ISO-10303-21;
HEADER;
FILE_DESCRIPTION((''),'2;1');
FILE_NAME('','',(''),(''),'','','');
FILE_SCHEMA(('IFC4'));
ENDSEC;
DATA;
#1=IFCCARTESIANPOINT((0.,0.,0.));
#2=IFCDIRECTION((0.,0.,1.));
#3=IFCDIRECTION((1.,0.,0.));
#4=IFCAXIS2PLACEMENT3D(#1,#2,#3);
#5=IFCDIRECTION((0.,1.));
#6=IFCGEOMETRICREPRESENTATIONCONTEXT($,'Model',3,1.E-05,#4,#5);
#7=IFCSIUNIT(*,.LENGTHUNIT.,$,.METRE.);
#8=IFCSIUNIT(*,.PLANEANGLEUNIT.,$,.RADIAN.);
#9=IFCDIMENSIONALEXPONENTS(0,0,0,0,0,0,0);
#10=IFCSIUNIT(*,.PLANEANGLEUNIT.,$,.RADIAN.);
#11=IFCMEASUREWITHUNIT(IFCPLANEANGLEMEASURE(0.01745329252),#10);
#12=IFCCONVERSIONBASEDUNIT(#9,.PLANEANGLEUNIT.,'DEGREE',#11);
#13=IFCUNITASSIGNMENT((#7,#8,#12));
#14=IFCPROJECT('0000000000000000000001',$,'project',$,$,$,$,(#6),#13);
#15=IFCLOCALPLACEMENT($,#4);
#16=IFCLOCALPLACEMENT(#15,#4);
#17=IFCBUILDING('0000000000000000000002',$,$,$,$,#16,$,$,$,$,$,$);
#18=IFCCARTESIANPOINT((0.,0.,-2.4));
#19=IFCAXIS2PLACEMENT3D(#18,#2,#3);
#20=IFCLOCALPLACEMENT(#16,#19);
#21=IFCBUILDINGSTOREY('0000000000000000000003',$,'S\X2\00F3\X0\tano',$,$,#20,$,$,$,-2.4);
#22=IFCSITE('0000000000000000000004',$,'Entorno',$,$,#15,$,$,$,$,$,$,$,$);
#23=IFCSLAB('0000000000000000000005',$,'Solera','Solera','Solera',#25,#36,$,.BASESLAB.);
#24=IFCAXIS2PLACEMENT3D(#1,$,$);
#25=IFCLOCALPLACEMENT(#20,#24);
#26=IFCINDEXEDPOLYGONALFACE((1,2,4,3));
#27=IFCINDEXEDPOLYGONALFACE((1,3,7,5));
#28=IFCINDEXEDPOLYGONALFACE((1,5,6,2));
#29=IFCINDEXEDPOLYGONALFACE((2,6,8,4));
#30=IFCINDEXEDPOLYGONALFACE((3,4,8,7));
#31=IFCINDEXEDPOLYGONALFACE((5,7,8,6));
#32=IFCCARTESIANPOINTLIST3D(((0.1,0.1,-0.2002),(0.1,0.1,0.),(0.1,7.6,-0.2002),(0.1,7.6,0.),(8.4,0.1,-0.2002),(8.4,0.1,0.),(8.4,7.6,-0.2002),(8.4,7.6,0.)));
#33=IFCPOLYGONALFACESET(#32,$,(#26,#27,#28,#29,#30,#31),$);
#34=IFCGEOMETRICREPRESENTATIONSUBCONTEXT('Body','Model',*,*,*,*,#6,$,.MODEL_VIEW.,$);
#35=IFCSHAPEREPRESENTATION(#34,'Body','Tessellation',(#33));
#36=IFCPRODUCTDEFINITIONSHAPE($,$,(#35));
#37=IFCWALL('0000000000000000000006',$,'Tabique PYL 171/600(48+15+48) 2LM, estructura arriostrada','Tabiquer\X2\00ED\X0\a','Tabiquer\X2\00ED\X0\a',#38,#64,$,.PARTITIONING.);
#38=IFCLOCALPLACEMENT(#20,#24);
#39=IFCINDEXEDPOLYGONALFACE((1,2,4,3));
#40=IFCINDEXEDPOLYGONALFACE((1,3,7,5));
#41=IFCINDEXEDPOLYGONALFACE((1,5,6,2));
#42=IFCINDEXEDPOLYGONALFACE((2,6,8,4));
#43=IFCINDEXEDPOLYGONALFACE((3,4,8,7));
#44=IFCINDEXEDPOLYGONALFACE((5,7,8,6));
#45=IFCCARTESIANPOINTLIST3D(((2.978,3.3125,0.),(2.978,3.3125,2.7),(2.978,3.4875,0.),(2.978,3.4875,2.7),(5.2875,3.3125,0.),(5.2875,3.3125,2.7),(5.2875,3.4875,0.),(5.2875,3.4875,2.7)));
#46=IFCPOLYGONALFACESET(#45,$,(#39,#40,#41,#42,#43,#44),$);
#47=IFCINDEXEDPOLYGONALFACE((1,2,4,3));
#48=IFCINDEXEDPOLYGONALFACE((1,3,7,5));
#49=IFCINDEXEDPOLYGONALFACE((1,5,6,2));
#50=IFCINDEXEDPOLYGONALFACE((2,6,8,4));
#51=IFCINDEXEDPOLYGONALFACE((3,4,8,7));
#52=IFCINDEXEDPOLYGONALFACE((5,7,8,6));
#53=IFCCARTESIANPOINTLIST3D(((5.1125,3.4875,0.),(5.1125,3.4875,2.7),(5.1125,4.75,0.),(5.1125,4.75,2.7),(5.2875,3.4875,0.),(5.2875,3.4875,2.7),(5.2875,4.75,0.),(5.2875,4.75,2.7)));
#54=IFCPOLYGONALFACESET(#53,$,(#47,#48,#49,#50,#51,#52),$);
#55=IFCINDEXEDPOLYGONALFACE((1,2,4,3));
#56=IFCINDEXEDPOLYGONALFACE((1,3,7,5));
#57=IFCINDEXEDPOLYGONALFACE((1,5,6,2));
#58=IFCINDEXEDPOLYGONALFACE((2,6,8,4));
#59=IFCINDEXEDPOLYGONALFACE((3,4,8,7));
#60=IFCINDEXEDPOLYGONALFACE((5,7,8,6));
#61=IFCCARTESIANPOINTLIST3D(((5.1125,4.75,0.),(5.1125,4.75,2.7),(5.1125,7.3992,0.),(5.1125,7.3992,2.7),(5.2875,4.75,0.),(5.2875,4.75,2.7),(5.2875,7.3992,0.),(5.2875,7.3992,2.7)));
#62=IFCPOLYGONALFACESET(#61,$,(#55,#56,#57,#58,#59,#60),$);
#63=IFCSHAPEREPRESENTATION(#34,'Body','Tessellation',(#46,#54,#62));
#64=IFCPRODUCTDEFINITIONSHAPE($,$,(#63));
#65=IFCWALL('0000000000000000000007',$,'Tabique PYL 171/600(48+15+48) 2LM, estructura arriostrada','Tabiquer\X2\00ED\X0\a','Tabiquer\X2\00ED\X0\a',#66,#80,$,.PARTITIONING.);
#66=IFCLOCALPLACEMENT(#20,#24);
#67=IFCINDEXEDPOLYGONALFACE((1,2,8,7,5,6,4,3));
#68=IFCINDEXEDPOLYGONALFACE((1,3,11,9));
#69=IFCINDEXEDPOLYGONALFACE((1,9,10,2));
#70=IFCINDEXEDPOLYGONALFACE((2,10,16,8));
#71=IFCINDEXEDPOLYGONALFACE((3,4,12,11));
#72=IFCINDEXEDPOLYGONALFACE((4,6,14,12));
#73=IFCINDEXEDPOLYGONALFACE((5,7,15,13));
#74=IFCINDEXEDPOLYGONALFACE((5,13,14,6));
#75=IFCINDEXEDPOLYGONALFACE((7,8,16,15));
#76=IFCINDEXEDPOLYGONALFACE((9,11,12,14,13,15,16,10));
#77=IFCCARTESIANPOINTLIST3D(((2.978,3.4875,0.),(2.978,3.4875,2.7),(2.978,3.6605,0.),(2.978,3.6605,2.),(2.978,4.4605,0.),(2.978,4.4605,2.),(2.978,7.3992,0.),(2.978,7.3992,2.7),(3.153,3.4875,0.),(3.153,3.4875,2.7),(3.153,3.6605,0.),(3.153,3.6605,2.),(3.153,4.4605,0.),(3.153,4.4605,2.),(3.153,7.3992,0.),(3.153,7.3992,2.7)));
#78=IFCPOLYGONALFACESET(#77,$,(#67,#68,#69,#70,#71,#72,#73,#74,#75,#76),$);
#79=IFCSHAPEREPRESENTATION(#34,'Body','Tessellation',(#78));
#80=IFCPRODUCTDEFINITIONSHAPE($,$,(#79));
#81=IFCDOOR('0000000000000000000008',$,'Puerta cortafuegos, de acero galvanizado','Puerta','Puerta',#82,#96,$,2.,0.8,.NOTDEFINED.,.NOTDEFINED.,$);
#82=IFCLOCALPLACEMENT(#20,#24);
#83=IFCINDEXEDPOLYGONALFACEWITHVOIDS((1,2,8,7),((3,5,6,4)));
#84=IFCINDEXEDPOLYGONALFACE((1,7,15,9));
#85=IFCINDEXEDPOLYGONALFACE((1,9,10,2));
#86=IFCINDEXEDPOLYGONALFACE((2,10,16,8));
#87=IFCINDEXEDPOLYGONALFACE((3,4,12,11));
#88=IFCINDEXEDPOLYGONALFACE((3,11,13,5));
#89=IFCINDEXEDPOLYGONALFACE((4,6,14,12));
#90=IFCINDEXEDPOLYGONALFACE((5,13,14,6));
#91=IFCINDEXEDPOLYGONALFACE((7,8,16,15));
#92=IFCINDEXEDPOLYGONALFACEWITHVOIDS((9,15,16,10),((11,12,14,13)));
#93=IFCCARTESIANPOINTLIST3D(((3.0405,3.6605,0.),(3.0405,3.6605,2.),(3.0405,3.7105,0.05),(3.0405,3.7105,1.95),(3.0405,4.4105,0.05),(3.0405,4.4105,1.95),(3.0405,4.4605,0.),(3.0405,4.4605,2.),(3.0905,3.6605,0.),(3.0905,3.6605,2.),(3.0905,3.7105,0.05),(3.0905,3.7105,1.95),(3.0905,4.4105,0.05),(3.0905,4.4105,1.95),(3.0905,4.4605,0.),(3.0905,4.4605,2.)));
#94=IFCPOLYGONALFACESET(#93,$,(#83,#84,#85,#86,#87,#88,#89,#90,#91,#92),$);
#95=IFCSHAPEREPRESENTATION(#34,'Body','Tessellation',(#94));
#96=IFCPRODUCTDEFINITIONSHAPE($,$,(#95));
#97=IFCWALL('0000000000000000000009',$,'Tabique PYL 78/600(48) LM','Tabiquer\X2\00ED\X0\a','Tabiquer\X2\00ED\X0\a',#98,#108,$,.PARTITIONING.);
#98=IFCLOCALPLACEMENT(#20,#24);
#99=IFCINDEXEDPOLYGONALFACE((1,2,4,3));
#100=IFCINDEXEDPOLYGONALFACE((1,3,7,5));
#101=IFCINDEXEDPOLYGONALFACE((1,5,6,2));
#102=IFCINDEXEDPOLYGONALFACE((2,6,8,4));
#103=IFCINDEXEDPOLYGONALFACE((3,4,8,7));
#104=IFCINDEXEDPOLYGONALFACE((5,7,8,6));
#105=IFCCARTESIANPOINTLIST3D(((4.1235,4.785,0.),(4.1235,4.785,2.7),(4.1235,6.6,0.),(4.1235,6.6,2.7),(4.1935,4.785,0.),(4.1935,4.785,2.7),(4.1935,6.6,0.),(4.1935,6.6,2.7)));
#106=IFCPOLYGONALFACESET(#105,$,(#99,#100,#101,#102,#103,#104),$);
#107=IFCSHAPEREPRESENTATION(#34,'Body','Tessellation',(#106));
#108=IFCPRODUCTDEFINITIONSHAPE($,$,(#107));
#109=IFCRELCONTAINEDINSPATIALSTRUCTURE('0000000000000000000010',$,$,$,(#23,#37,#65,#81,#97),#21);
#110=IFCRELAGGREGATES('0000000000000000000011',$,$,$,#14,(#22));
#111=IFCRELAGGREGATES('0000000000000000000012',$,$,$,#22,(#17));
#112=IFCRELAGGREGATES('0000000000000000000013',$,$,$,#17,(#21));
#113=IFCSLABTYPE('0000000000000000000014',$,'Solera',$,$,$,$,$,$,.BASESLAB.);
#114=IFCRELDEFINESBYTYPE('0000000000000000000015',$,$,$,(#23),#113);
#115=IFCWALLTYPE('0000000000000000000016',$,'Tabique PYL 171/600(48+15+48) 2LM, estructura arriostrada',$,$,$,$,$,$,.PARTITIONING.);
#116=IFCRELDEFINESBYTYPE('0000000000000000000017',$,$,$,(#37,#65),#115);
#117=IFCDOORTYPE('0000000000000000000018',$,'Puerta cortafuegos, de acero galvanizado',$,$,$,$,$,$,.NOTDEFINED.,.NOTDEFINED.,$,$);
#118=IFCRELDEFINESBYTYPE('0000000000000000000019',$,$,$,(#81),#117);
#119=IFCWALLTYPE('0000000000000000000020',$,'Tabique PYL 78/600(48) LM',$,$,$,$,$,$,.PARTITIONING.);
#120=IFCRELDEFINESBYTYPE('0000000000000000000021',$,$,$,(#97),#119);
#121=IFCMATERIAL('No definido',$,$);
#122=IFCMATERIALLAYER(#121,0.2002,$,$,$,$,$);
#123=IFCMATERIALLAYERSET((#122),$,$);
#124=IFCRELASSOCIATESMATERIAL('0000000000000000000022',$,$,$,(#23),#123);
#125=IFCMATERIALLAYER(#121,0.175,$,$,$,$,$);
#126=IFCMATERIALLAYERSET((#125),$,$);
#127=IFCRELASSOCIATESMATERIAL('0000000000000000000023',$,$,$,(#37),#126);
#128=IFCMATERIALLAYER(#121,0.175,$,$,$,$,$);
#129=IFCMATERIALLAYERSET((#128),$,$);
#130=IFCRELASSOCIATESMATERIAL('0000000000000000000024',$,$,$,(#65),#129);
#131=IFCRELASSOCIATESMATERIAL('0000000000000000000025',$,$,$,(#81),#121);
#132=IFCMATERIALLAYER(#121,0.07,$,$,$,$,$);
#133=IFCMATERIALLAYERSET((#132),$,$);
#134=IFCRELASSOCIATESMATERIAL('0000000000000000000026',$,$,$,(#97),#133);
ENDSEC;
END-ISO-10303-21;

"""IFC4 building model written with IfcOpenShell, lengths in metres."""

from ifc_helpers import new_model, entity, si_unit, converted_unit, direction, frame, origin_with_axes, origin_2d_with_axis, place, context, subcontext, project, spatial, polyline, rectangle, hollow_rectangle, outline, extrude, shape, material, layer, layer_set, layer_usage, type_object, element, fill, save


model = new_model("IFC4")

# Units and contexts
model_context = context("Model", 3, precision=1e-05, world=origin_with_axes(), true_north=direction((0.0, 1.0)))
body_context = subcontext(model_context, "Body", "Model", "MODEL_VIEW")
footprint_context = subcontext(model_context, "FootPrint", "Model", "MODEL_VIEW")
ifc_project = project(units=[si_unit("LENGTHUNIT", "METRE"), si_unit("PLANEANGLEUNIT", "RADIAN"), converted_unit("PLANEANGLEUNIT", "DEGREE", entity("IfcPlaneAngleMeasure", 0.01745329252), si_unit("PLANEANGLEUNIT", "RADIAN"), dimensions=[0, 0, 0, 0, 0, 0, 0])], contexts=[model_context])

# Site, building, storey
site_placement = place(None, origin_with_axes())
site = spatial("IfcSite", under=ifc_project, at=site_placement, Name="Entorno")
building_placement = place(site_placement, origin_with_axes())
building = spatial("IfcBuilding", under=site, at=building_placement)
storey_placement = place(building_placement, frame((0.0, 0.0, -2.4), z_axis=(0.0, 0.0, 1.0), x_axis=(1.0, 0.0, 0.0)))
storey = spatial("IfcBuildingStorey", under=building, at=storey_placement, Name="Sótano", Elevation=-2.4)

# Slab
ifc_material = material(Name="No definido")
ifc_layer_1 = layer(ifc_material, 0.2002)
ifc_layer_set_1 = layer_set([ifc_layer_1])
ifc_layer_usage_1 = layer_usage(ifc_layer_set_1, "AXIS3", "POSITIVE", 0.0)
slab_type = type_object("IfcSlabType", Name="Solera", PredefinedType="BASESLAB")
slab_placement = place(storey_placement, frame((0.1, 0.1, -0.2002), z_axis=(0.0, 0.0, 1.0), x_axis=(1.0, 0.0, 0.0)))
element("IfcSlab", 1, at=slab_placement, inside=storey, type_object=slab_type, material=ifc_layer_usage_1, Name="Solera", Description="Solera", ObjectType="Solera", PredefinedType="BASESLAB", context=body_context, shape_type="SweptSolid", body=[
    extrude(outline(polyline([(0.0, 0.0), (8.3, 0.0), (8.3, 7.5), (0.0, 7.5), (0.0, 0.0)])), origin_with_axes(), (0.0, 0.0, 1.0), 0.2002),
])

# Wall
ifc_layer_2 = layer(ifc_material, 0.175)
ifc_layer_set_2 = layer_set([ifc_layer_2])
ifc_layer_usage_2 = layer_usage(ifc_layer_set_2, "AXIS2", "POSITIVE", -0.0875)
wall_type_1 = type_object("IfcWallType", Name="Tabique PYL 171/600(48+15+48) 2LM, estructura arriostrada", PredefinedType="PARTITIONING")
wall_1_placement = place(storey_placement, frame((3.0655, 3.4, 0.0), z_axis=(0.0, 0.0, 1.0), x_axis=(1.0, 0.0, 0.0)))
cartesian_point_1 = entity("IfcCartesianPoint", [-1.1547, -1.35])
cartesian_point_2 = entity("IfcCartesianPoint", [-1.1547, -1.35])
cartesian_point_3 = entity("IfcCartesianPoint", [-0.6312, -1.35])
cartesian_point_4 = entity("IfcCartesianPoint", [-0.6312, -1.35])
cartesian_point_5 = entity("IfcCartesianPoint", [-1.3246, -1.35])
cartesian_point_6 = entity("IfcCartesianPoint", [-1.3246, -1.35])
element("IfcWall", 2, at=wall_1_placement, inside=storey, type_object=wall_type_1, material=ifc_layer_usage_2, Name="Tabique PYL 171/600(48+15+48) 2LM, estructura arriostrada", Description="Tabiquería", ObjectType="Tabiquería", PredefinedType="PARTITIONING", context=body_context, shape_type="SolidModel", body=[
    entity("IfcExtrudedAreaSolidTapered", entity("IfcArbitraryClosedProfileDef", "AREA", None, entity("IfcPolyline", [cartesian_point_1, entity("IfcCartesianPoint", [1.1547, -1.35]), entity("IfcCartesianPoint", [1.1547, 1.35]), entity("IfcCartesianPoint", [-1.1547, 1.35]), cartesian_point_1])), entity("IfcAxis2Placement3D", entity("IfcCartesianPoint", [1.0673, 0.0875, 1.35]), entity("IfcDirection", [0.0, -1.0, 0.0]), entity("IfcDirection", [1.0, 0.0, 0.0])), entity("IfcDirection", [0.0, 0.0, 1.0]), 0.175, entity("IfcArbitraryClosedProfileDef", "AREA", None, entity("IfcPolyline", [cartesian_point_2, entity("IfcCartesianPoint", [1.1547, -1.35]), entity("IfcCartesianPoint", [1.1547, 1.35]), entity("IfcCartesianPoint", [-1.1547, 1.35]), cartesian_point_2]))),
    entity("IfcExtrudedAreaSolidTapered", entity("IfcArbitraryClosedProfileDef", "AREA", None, entity("IfcPolyline", [cartesian_point_3, entity("IfcCartesianPoint", [0.6312, -1.35]), entity("IfcCartesianPoint", [0.6312, 1.35]), entity("IfcCartesianPoint", [-0.6312, 1.35]), cartesian_point_3])), entity("IfcAxis2Placement3D", entity("IfcCartesianPoint", [2.047, 0.7188, 1.35]), entity("IfcDirection", [1.0, 0.0, 0.0]), entity("IfcDirection", [0.0, 1.0, 0.0])), entity("IfcDirection", [0.0, 0.0, 1.0]), 0.175, entity("IfcArbitraryClosedProfileDef", "AREA", None, entity("IfcPolyline", [cartesian_point_4, entity("IfcCartesianPoint", [0.6312, -1.35]), entity("IfcCartesianPoint", [0.6312, 1.35]), entity("IfcCartesianPoint", [-0.6312, 1.35]), cartesian_point_4]))),
    entity("IfcExtrudedAreaSolidTapered", entity("IfcArbitraryClosedProfileDef", "AREA", None, entity("IfcPolyline", [cartesian_point_5, entity("IfcCartesianPoint", [1.3246, -1.35]), entity("IfcCartesianPoint", [1.3246, 1.35]), entity("IfcCartesianPoint", [-1.3246, 1.35]), cartesian_point_5])), entity("IfcAxis2Placement3D", entity("IfcCartesianPoint", [2.047, 2.6746, 1.35]), entity("IfcDirection", [1.0, 0.0, 0.0]), entity("IfcDirection", [0.0, 1.0, 0.0])), entity("IfcDirection", [0.0, 0.0, 1.0]), 0.175, entity("IfcArbitraryClosedProfileDef", "AREA", None, entity("IfcPolyline", [cartesian_point_6, entity("IfcCartesianPoint", [1.3246, -1.35]), entity("IfcCartesianPoint", [1.3246, 1.35]), entity("IfcCartesianPoint", [-1.3246, 1.35]), cartesian_point_6]))),
])

# Wall, opening, door
ifc_layer_3 = layer(ifc_material, 0.175)
ifc_layer_set_3 = layer_set([ifc_layer_3])
ifc_layer_usage_3 = layer_usage(ifc_layer_set_3, "AXIS2", "POSITIVE", -0.0875)
wall_2_placement = place(storey_placement, frame((3.0655, 3.4, 0.0), z_axis=(0.0, 0.0, 1.0), x_axis=(0.0, 1.0, 0.0)))
cartesian_point_7 = entity("IfcCartesianPoint", [-1.9559, -1.35])
cartesian_point_8 = entity("IfcCartesianPoint", [-1.9559, -1.35])
wall_2 = element("IfcWall", 3, at=wall_2_placement, inside=storey, type_object=wall_type_1, material=ifc_layer_usage_3, Name="Tabique PYL 171/600(48+15+48) 2LM, estructura arriostrada", Description="Tabiquería", ObjectType="Tabiquería", PredefinedType="PARTITIONING", context=body_context, shape_type="SolidModel", body=[
    entity("IfcExtrudedAreaSolidTapered", entity("IfcArbitraryClosedProfileDef", "AREA", None, entity("IfcPolyline", [cartesian_point_7, entity("IfcCartesianPoint", [1.9559, -1.35]), entity("IfcCartesianPoint", [1.9559, 1.35]), entity("IfcCartesianPoint", [-1.9559, 1.35]), cartesian_point_7])), entity("IfcAxis2Placement3D", entity("IfcCartesianPoint", [2.0434, 0.0875, 1.35]), entity("IfcDirection", [0.0, -1.0, 0.0]), entity("IfcDirection", [1.0, 0.0, 0.0])), entity("IfcDirection", [0.0, 0.0, 1.0]), 0.175, entity("IfcArbitraryClosedProfileDef", "AREA", None, entity("IfcPolyline", [cartesian_point_8, entity("IfcCartesianPoint", [1.9559, -1.35]), entity("IfcCartesianPoint", [1.9559, 1.35]), entity("IfcCartesianPoint", [-1.9559, 1.35]), cartesian_point_8]))),
])
opening_1_placement = place(wall_2_placement, frame((0.6605, 0.0, 1.0), z_axis=(0.0, 0.0, 1.0), x_axis=(1.0, 0.0, 0.0)))
cartesian_point_9 = entity("IfcCartesianPoint", [-0.4, -0.0875])
opening_1 = element("IfcOpeningElement", 4, at=opening_1_placement, cuts=wall_2, ObjectType="No definido", PredefinedType="OPENING", shapes=[
    shape(body_context, "Body", "SweptSolid", [extrude(rectangle(XDim=2.0, YDim=0.8, at=origin_2d_with_axis()), frame((0.0, -0.0875, 0.0), z_axis=(0.0, 1.0, 0.0), x_axis=(0.0, 0.0, 1.0)), (0.0, 0.0, 1.0), 0.175)]),
    shape(footprint_context, "FootPrint", "GeometricCurveSet", [entity("IfcGeometricCurveSet", [entity("IfcPolyline", [cartesian_point_9, entity("IfcCartesianPoint", [0.4, -0.0875]), entity("IfcCartesianPoint", [0.4, 0.0875]), entity("IfcCartesianPoint", [-0.4, 0.0875]), cartesian_point_9])])]),
])
door_type_1 = type_object("IfcDoorType", Name="Puerta cortafuegos, de acero galvanizado", OperationType="NOTDEFINED", PredefinedType="NOTDEFINED")
door_1_placement = place(opening_1_placement, origin_with_axes())
door_1 = element("IfcDoor", 5, at=door_1_placement, inside=storey, type_object=door_type_1, material=ifc_material, Name="Puerta cortafuegos, de acero galvanizado", Description="Puerta", ObjectType="Puerta", OperationType="NOTDEFINED", OverallHeight=2.0, OverallWidth=0.8, PredefinedType="NOTDEFINED", context=body_context, shape_type="SweptSolid", body=[
    extrude(hollow_rectangle(XDim=0.8, YDim=2.0, WallThickness=0.05, InnerFilletRadius=0.0, OuterFilletRadius=0.0, at=origin_2d_with_axis()), frame((0.0, 0.025, 0.0), z_axis=(0.0, -1.0, 0.0), x_axis=(1.0, 0.0, 0.0)), (0.0, 0.0, 1.0), 0.05),
])
fill(opening_1, door_1)

# Wall
ifc_layer_4 = layer(ifc_material, 0.07)
ifc_layer_set_4 = layer_set([ifc_layer_4])
ifc_layer_usage_4 = layer_usage(ifc_layer_set_4, "AXIS2", "POSITIVE", -0.035)
wall_type_2 = type_object("IfcWallType", Name="Tabique PYL 78/600(48) LM", PredefinedType="PARTITIONING")
wall_3_placement = place(storey_placement, frame((4.1585, 4.75, 0.0), z_axis=(0.0, 0.0, 1.0), x_axis=(0.0, 1.0, 0.0)))
cartesian_point_10 = entity("IfcCartesianPoint", [-0.9075, -1.35])
cartesian_point_11 = entity("IfcCartesianPoint", [-0.9075, -1.35])
element("IfcWall", 6, at=wall_3_placement, inside=storey, type_object=wall_type_2, material=ifc_layer_usage_4, Name="Tabique PYL 78/600(48) LM", Description="Tabiquería", ObjectType="Tabiquería", PredefinedType="PARTITIONING", context=body_context, shape_type="SolidModel", body=[
    entity("IfcExtrudedAreaSolidTapered", entity("IfcArbitraryClosedProfileDef", "AREA", None, entity("IfcPolyline", [cartesian_point_10, entity("IfcCartesianPoint", [0.9075, -1.35]), entity("IfcCartesianPoint", [0.9075, 1.35]), entity("IfcCartesianPoint", [-0.9075, 1.35]), cartesian_point_10])), entity("IfcAxis2Placement3D", entity("IfcCartesianPoint", [0.9425, 0.035, 1.35]), entity("IfcDirection", [0.0, -1.0, 0.0]), entity("IfcDirection", [1.0, 0.0, 0.0])), entity("IfcDirection", [0.0, 0.0, 1.0]), 0.07, entity("IfcArbitraryClosedProfileDef", "AREA", None, entity("IfcPolyline", [cartesian_point_11, entity("IfcCartesianPoint", [0.9075, -1.35]), entity("IfcCartesianPoint", [0.9075, 1.35]), entity("IfcCartesianPoint", [-0.9075, 1.35]), cartesian_point_11]))),
])

save(model, "model.ifc")
